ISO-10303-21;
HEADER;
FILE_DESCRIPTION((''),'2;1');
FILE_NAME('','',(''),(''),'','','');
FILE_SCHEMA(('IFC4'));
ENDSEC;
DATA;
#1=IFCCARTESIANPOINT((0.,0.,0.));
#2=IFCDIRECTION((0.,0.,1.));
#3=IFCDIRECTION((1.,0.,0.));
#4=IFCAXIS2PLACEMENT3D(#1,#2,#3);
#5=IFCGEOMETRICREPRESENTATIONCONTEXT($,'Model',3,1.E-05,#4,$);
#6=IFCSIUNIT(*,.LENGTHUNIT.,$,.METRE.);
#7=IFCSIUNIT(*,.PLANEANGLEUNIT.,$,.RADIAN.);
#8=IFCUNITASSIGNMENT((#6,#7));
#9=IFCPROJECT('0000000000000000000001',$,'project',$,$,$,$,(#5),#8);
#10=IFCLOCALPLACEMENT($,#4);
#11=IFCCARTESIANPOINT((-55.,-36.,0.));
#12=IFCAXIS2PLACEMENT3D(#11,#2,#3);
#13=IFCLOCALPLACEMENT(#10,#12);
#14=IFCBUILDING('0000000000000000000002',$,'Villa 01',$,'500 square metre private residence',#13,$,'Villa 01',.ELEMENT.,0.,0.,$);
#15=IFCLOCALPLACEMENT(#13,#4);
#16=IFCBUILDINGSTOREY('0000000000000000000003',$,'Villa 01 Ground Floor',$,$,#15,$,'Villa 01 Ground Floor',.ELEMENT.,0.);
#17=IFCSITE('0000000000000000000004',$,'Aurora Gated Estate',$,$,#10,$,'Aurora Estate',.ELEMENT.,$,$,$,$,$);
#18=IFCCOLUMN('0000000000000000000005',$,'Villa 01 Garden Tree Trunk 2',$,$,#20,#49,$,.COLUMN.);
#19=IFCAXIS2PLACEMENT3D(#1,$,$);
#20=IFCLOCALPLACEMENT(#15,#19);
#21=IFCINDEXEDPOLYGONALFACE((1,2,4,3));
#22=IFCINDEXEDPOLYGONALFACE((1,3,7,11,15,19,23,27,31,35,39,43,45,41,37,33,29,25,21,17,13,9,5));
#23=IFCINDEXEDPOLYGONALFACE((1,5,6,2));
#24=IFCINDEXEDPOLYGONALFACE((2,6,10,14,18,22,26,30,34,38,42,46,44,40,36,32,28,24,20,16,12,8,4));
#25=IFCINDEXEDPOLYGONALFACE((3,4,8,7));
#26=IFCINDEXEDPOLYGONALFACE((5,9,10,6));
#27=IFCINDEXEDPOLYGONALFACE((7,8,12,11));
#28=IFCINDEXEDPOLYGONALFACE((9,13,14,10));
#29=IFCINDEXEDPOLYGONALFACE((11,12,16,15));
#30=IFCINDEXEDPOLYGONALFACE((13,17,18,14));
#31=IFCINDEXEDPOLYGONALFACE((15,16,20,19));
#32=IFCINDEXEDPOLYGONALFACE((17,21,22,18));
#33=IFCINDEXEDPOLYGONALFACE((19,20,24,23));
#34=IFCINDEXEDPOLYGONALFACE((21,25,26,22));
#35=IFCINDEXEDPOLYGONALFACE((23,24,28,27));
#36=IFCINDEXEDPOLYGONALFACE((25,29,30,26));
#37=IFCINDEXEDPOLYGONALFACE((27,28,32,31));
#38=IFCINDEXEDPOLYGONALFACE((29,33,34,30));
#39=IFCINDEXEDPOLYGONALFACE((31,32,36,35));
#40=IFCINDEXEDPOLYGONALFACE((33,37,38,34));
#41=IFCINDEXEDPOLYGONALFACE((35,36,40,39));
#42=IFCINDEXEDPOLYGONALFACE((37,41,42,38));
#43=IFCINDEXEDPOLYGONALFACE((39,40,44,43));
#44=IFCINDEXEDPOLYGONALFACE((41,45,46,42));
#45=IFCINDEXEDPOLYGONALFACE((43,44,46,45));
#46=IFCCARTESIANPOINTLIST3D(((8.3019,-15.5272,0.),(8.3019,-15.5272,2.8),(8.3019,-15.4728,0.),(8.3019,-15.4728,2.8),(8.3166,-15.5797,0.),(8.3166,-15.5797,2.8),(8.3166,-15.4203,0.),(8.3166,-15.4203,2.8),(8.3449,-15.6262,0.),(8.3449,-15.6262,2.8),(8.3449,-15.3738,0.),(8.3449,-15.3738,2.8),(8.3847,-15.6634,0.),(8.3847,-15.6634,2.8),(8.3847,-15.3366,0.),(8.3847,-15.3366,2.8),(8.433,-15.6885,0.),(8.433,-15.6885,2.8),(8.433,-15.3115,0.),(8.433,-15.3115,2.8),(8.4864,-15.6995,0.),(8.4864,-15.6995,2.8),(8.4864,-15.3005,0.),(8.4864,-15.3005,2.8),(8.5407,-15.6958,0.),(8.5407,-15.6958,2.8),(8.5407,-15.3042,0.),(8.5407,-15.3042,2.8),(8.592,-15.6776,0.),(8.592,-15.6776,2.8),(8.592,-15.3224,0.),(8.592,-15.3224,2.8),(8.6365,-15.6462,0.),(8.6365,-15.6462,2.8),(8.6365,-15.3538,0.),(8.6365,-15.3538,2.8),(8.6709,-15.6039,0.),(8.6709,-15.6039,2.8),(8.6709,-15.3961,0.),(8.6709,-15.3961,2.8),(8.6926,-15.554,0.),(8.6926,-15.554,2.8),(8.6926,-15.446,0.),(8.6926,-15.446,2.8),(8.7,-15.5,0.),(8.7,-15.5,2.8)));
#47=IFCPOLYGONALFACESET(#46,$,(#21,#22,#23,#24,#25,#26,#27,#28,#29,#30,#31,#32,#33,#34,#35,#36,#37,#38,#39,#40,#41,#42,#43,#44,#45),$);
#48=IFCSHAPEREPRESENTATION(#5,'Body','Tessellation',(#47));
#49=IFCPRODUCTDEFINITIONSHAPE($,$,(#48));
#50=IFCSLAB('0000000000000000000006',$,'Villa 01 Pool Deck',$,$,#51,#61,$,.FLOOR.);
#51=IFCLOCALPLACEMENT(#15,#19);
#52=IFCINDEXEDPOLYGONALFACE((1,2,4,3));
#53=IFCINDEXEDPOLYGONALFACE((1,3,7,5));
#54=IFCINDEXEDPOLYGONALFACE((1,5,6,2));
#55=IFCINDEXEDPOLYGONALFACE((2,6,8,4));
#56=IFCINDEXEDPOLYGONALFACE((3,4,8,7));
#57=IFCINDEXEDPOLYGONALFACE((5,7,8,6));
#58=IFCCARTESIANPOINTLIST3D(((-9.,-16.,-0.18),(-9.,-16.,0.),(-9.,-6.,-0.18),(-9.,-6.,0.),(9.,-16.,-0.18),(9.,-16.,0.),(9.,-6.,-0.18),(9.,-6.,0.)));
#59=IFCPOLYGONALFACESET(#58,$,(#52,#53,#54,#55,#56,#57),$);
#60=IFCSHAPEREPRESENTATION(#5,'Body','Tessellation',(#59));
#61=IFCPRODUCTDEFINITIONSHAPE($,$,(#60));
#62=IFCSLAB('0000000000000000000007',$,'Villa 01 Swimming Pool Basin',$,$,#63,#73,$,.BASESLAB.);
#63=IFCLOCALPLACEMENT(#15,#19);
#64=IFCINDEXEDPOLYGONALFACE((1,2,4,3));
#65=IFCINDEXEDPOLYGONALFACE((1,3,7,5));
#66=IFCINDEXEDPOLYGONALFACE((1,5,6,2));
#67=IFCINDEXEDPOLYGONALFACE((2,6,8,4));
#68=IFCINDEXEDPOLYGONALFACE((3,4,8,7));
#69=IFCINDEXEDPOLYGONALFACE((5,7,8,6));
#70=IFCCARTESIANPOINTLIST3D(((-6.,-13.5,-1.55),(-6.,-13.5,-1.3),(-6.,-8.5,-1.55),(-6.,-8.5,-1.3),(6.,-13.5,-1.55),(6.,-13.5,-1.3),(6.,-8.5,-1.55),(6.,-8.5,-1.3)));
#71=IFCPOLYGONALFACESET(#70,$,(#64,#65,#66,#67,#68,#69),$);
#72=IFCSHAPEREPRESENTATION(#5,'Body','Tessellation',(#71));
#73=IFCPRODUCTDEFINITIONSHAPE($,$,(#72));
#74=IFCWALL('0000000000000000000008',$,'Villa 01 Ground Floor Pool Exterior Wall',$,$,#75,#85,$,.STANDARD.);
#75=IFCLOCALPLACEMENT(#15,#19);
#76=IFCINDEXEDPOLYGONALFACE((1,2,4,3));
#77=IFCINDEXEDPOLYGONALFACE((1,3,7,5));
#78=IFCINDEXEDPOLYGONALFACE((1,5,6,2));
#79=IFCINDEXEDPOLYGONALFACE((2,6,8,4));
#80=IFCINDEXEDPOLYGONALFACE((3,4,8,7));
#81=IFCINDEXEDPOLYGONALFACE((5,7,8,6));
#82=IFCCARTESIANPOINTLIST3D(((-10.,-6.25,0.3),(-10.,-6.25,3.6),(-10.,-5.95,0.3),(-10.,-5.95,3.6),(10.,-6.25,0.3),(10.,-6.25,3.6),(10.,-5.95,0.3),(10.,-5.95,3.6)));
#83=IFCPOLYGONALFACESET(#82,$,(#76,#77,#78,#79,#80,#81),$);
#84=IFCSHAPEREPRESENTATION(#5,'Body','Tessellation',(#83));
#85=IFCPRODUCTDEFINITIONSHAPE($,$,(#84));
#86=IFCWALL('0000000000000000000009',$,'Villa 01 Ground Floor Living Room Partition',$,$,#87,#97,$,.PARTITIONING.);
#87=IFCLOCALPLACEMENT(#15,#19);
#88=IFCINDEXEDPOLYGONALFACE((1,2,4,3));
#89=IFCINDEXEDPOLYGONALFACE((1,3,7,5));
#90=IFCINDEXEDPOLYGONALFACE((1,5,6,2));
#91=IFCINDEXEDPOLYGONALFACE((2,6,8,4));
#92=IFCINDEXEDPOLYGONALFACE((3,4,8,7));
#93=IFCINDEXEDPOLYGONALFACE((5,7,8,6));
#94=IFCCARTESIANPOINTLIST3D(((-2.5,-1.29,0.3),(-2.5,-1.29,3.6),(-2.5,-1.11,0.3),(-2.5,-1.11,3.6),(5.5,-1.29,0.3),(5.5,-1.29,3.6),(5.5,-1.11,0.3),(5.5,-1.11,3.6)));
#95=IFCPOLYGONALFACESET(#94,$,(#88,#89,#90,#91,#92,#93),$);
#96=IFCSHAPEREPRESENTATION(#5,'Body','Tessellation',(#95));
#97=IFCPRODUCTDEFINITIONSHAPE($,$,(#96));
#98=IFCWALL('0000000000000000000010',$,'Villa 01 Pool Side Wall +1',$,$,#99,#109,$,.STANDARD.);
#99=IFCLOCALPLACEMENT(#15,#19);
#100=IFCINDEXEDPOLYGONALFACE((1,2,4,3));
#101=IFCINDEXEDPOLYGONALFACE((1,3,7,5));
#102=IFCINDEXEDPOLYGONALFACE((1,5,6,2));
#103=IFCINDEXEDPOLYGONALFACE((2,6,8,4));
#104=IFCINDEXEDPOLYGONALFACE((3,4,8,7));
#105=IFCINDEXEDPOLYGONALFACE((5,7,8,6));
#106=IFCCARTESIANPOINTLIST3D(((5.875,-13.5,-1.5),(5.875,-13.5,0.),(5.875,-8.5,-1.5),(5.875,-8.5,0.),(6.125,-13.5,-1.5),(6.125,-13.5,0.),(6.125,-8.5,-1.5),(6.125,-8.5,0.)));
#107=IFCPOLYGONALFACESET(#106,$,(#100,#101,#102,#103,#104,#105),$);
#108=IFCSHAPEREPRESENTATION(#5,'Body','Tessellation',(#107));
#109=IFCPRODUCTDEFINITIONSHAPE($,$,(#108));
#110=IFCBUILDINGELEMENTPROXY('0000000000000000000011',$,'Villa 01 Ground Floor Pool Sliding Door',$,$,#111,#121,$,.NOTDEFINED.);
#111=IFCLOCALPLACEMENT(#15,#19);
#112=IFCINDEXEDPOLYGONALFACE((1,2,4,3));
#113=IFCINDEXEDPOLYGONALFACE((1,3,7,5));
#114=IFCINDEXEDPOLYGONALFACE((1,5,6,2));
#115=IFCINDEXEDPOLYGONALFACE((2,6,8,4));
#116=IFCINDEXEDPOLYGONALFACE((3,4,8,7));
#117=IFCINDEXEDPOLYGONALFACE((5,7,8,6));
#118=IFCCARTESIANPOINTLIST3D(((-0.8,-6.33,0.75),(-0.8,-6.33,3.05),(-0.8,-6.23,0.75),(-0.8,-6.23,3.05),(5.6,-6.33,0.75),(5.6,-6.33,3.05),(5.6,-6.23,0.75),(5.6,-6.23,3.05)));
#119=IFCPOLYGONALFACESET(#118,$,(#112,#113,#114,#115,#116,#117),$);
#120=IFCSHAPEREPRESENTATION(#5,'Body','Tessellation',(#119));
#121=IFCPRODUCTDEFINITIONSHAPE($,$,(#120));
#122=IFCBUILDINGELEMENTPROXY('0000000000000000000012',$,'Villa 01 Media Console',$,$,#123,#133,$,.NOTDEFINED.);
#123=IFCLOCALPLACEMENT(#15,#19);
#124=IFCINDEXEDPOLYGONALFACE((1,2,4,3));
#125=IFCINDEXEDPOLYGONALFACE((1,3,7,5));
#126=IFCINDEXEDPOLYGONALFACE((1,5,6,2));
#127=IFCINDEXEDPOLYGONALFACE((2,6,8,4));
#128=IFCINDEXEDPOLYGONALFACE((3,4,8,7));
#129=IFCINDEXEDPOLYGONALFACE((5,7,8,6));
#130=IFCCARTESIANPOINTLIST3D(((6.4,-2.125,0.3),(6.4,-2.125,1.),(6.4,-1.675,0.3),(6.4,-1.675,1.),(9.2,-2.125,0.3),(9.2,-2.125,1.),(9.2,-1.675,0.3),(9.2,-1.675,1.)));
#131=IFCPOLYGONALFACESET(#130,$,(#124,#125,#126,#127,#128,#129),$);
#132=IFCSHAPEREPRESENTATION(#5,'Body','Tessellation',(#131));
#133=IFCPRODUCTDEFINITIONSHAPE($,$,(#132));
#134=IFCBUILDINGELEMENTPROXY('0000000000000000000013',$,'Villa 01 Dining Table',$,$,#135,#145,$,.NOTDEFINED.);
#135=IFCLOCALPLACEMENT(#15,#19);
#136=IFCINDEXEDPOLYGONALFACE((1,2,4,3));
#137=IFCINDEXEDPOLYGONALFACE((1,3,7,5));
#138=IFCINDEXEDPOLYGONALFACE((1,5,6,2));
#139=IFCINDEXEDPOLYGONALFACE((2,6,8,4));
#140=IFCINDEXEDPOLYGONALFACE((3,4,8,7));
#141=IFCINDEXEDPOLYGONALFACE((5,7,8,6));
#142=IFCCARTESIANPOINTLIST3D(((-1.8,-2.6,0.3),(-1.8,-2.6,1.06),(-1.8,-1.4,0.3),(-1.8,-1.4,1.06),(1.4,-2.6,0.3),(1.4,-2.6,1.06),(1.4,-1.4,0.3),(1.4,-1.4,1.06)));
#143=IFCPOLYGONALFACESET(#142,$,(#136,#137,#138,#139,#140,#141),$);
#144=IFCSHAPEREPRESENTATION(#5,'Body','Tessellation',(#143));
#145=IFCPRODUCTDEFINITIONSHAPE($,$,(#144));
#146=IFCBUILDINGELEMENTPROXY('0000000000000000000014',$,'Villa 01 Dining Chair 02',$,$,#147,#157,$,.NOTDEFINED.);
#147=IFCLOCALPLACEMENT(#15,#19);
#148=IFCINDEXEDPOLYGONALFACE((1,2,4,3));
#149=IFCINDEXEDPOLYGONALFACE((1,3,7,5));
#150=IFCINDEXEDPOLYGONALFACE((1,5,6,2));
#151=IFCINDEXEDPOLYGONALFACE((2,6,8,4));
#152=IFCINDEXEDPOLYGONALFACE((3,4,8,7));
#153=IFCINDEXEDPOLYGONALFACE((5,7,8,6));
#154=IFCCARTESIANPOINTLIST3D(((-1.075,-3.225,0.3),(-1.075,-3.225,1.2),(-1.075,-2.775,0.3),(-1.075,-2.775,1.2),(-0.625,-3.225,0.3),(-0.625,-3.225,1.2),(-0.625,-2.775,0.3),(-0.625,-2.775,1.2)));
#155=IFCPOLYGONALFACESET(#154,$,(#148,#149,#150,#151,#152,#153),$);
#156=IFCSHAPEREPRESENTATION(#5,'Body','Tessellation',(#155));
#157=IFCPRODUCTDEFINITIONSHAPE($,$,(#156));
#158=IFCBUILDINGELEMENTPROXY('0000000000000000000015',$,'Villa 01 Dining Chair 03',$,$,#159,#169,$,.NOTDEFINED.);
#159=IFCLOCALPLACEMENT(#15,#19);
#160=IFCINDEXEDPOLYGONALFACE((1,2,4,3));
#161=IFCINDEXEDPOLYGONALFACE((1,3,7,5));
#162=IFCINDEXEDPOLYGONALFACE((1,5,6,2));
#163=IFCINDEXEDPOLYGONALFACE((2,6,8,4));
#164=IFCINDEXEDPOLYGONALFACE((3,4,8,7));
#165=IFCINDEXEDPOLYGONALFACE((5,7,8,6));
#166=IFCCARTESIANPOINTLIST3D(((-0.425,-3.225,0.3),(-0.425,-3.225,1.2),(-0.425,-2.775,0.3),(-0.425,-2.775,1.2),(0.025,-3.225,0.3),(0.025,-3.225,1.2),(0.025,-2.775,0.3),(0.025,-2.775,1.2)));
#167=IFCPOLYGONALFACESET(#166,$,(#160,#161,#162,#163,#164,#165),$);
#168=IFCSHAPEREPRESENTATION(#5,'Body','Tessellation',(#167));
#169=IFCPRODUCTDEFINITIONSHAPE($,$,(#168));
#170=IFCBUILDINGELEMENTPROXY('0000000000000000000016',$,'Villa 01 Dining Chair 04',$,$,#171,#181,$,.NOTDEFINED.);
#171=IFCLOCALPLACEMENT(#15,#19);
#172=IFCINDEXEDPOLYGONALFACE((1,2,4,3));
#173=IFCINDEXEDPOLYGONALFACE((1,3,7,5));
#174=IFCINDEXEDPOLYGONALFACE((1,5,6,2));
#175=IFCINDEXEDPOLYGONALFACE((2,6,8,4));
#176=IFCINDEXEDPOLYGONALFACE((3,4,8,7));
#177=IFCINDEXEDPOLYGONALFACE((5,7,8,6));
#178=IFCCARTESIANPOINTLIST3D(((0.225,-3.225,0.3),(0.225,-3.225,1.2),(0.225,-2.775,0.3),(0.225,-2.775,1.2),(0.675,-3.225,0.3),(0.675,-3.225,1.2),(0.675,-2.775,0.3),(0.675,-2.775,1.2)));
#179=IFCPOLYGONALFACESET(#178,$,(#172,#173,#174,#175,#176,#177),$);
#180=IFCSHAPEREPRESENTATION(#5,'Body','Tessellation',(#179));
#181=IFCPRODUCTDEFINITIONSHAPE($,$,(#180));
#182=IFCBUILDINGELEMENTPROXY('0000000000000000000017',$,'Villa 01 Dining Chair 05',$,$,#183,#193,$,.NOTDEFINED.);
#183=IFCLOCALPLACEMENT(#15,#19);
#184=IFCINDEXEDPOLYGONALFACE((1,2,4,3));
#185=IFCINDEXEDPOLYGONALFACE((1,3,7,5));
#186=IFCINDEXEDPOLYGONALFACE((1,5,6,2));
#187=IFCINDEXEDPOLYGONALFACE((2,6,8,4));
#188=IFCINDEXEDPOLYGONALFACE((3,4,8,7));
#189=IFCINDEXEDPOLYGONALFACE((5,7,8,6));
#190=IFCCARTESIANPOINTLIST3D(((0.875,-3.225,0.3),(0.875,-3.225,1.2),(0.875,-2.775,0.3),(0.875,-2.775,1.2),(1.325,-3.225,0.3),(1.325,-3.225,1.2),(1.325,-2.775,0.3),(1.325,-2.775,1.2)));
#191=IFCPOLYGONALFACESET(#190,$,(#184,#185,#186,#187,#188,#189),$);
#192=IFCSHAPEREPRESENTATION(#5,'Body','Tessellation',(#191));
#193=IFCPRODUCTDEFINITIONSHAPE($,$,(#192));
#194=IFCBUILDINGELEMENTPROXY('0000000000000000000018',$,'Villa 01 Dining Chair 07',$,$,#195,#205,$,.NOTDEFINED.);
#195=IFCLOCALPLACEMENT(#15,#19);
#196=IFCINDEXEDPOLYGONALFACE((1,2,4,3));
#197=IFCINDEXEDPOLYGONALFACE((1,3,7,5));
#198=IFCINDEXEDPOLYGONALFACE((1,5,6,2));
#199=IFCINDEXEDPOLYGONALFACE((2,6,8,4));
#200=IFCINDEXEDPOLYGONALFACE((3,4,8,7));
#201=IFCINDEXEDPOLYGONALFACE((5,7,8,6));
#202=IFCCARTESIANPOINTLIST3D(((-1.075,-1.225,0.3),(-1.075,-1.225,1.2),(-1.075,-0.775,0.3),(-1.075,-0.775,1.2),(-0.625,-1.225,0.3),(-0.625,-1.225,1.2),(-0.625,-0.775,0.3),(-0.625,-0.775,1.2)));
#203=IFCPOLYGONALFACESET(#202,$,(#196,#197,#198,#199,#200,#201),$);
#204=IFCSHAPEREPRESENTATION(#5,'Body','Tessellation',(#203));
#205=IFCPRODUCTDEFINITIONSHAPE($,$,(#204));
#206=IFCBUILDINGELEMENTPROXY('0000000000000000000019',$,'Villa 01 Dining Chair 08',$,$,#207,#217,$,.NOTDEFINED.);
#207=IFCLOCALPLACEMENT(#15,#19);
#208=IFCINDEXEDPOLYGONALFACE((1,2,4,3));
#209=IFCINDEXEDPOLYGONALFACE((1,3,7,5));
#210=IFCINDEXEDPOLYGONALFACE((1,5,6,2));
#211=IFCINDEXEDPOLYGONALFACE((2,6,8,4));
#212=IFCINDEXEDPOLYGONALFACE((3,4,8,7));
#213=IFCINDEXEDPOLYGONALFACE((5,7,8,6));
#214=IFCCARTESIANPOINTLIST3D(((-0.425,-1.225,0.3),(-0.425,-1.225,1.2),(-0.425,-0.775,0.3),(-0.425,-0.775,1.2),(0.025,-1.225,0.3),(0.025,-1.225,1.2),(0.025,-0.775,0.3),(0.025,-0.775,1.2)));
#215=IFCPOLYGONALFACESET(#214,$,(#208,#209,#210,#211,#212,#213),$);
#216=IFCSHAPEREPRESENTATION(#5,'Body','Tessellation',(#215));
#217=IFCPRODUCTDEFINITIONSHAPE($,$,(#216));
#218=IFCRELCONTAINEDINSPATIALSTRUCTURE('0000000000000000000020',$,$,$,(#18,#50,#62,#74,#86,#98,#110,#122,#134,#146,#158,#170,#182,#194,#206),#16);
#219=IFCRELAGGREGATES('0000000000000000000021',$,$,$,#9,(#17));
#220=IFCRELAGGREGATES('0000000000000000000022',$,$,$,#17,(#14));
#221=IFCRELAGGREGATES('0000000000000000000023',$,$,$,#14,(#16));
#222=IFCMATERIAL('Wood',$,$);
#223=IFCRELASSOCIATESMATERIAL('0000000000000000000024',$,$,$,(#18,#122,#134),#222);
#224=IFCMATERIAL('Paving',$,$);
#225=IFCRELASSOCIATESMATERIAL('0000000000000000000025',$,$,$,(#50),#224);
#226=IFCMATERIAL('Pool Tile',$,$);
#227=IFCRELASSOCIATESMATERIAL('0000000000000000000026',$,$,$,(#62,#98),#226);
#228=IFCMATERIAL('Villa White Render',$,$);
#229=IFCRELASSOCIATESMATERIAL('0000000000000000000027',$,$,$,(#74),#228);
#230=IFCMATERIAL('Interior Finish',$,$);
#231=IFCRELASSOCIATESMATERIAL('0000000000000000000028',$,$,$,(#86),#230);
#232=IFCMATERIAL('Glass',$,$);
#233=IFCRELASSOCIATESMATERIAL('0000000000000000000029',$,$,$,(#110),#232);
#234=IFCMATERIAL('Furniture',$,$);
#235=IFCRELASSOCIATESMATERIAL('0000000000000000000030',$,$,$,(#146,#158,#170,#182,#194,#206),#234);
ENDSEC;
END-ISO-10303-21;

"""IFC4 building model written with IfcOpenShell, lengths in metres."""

from ifc_helpers import new_model, si_unit, frame, origin_with_axes, origin_2d_with_axis, place, context, project, spatial, rectangle, circle, extrude, material, element, save


model = new_model("IFC4")

# Units and contexts
model_context = context("Model", 3, precision=1e-05, world=origin_with_axes())
ifc_project = project(units=[si_unit("LENGTHUNIT", "METRE"), si_unit("PLANEANGLEUNIT", "RADIAN")], contexts=[model_context])

# Site, building, storey
site_placement = place(None, origin_with_axes())
site = spatial("IfcSite", under=ifc_project, at=site_placement, Name="Aurora Gated Estate", LongName="Aurora Estate", CompositionType="ELEMENT")
building_placement = place(site_placement, frame((-55.0, -36.0, 0.0), z_axis=(0.0, 0.0, 1.0), x_axis=(1.0, 0.0, 0.0)))
building = spatial("IfcBuilding", under=site, at=building_placement, Name="Villa 01", ObjectType="500 square metre private residence", LongName="Villa 01", CompositionType="ELEMENT", ElevationOfRefHeight=0.0, ElevationOfTerrain=0.0)
storey_placement = place(building_placement, origin_with_axes())
storey = spatial("IfcBuildingStorey", under=building, at=storey_placement, Name="Villa 01 Ground Floor", LongName="Villa 01 Ground Floor", CompositionType="ELEMENT", Elevation=0.0)

# Column
ifc_material_1 = material(Name="Wood")
column_placement = place(storey_placement, frame((8.5, -15.5, 0.0), z_axis=(0.0, 0.0, 1.0), x_axis=(1.0, 0.0, 0.0)))
element("IfcColumn", 1, at=column_placement, inside=storey, material=ifc_material_1, Name="Villa 01 Garden Tree Trunk 2", PredefinedType="COLUMN", context=model_context, shape_type="SweptSolid", body=[
    extrude(circle(Radius=0.2, at=origin_2d_with_axis()), origin_with_axes(), (0.0, 0.0, 1.0), 2.8),
])

# Slabs
ifc_material_2 = material(Name="Paving")
slab_1_placement = place(storey_placement, frame((0.0, -11.0, -0.18), z_axis=(0.0, 0.0, 1.0), x_axis=(1.0, 0.0, 0.0)))
element("IfcSlab", 2, at=slab_1_placement, inside=storey, material=ifc_material_2, Name="Villa 01 Pool Deck", PredefinedType="FLOOR", context=model_context, shape_type="SweptSolid", body=[
    extrude(rectangle(XDim=18.0, YDim=10.0, at=origin_2d_with_axis()), origin_with_axes(), (0.0, 0.0, 1.0), 0.18),
])
ifc_material_3 = material(Name="Pool Tile")
slab_2_placement = place(storey_placement, frame((0.0, -11.0, -1.55), z_axis=(0.0, 0.0, 1.0), x_axis=(1.0, 0.0, 0.0)))
element("IfcSlab", 3, at=slab_2_placement, inside=storey, material=ifc_material_3, Name="Villa 01 Swimming Pool Basin", PredefinedType="BASESLAB", context=model_context, shape_type="SweptSolid", body=[
    extrude(rectangle(XDim=12.0, YDim=5.0, at=origin_2d_with_axis()), origin_with_axes(), (0.0, 0.0, 1.0), 0.25),
])

# Walls
ifc_material_4 = material(Name="Villa White Render")
wall_1_placement = place(storey_placement, frame((0.0, -6.1, 0.3), z_axis=(0.0, 0.0, 1.0), x_axis=(1.0, 0.0, 0.0)))
element("IfcWall", 4, at=wall_1_placement, inside=storey, material=ifc_material_4, Name="Villa 01 Ground Floor Pool Exterior Wall", PredefinedType="STANDARD", context=model_context, shape_type="SweptSolid", body=[
    extrude(rectangle(XDim=20.0, YDim=0.3, at=origin_2d_with_axis()), origin_with_axes(), (0.0, 0.0, 1.0), 3.3),
])
ifc_material_5 = material(Name="Interior Finish")
wall_2_placement = place(storey_placement, frame((1.5, -1.2, 0.3), z_axis=(0.0, 0.0, 1.0), x_axis=(1.0, 0.0, 0.0)))
element("IfcWall", 5, at=wall_2_placement, inside=storey, material=ifc_material_5, Name="Villa 01 Ground Floor Living Room Partition", PredefinedType="PARTITIONING", context=model_context, shape_type="SweptSolid", body=[
    extrude(rectangle(XDim=8.0, YDim=0.18, at=origin_2d_with_axis()), origin_with_axes(), (0.0, 0.0, 1.0), 3.3),
])
wall_3_placement = place(storey_placement, frame((6.0, -11.0, -1.5), z_axis=(0.0, 0.0, 1.0), x_axis=(1.0, 0.0, 0.0)))
element("IfcWall", 6, at=wall_3_placement, inside=storey, material=ifc_material_3, Name="Villa 01 Pool Side Wall +1", PredefinedType="STANDARD", context=model_context, shape_type="SweptSolid", body=[
    extrude(rectangle(XDim=0.25, YDim=5.0, at=origin_2d_with_axis()), origin_with_axes(), (0.0, 0.0, 1.0), 1.5),
])

# Building element proxies
ifc_material_6 = material(Name="Glass")
proxy_1_placement = place(storey_placement, frame((2.4, -6.28, 0.75), z_axis=(0.0, 0.0, 1.0), x_axis=(1.0, 0.0, 0.0)))
element("IfcBuildingElementProxy", 7, at=proxy_1_placement, inside=storey, material=ifc_material_6, Name="Villa 01 Ground Floor Pool Sliding Door", PredefinedType="NOTDEFINED", context=model_context, shape_type="SweptSolid", body=[
    extrude(rectangle(XDim=6.4, YDim=0.1, at=origin_2d_with_axis()), origin_with_axes(), (0.0, 0.0, 1.0), 2.3),
])
proxy_2_placement = place(storey_placement, frame((7.8, -1.9, 0.3), z_axis=(0.0, 0.0, 1.0), x_axis=(1.0, 0.0, 0.0)))
element("IfcBuildingElementProxy", 8, at=proxy_2_placement, inside=storey, material=ifc_material_1, Name="Villa 01 Media Console", PredefinedType="NOTDEFINED", context=model_context, shape_type="SweptSolid", body=[
    extrude(rectangle(XDim=2.8, YDim=0.45, at=origin_2d_with_axis()), origin_with_axes(), (0.0, 0.0, 1.0), 0.7),
])
proxy_3_placement = place(storey_placement, frame((-0.2, -2.0, 0.3), z_axis=(0.0, 0.0, 1.0), x_axis=(1.0, 0.0, 0.0)))
element("IfcBuildingElementProxy", 9, at=proxy_3_placement, inside=storey, material=ifc_material_1, Name="Villa 01 Dining Table", PredefinedType="NOTDEFINED", context=model_context, shape_type="SweptSolid", body=[
    extrude(rectangle(XDim=3.2, YDim=1.2, at=origin_2d_with_axis()), origin_with_axes(), (0.0, 0.0, 1.0), 0.76),
])
ifc_material_7 = material(Name="Furniture")
for number, where, z_axis, x_axis, name in (
    (10, (-0.85, -3.0, 0.3), (0.0, 0.0, 1.0), (1.0, 0.0, 0.0), "Villa 01 Dining Chair 02"),
    (11, (-0.2, -3.0, 0.3), (0.0, 0.0, 1.0), (1.0, 0.0, 0.0), "Villa 01 Dining Chair 03"),
    (12, (0.45, -3.0, 0.3), (0.0, 0.0, 1.0), (1.0, 0.0, 0.0), "Villa 01 Dining Chair 04"),
    (13, (1.1, -3.0, 0.3), (0.0, 0.0, 1.0), (1.0, 0.0, 0.0), "Villa 01 Dining Chair 05"),
    (14, (-0.85, -1.0, 0.3), (0.0, 0.0, 1.0), (1.0, 0.0, 0.0), "Villa 01 Dining Chair 07"),
    (15, (-0.2, -1.0, 0.3), (0.0, 0.0, 1.0), (1.0, 0.0, 0.0), "Villa 01 Dining Chair 08"),
):
    element("IfcBuildingElementProxy", number, at=place(storey_placement, frame(where, z_axis=z_axis, x_axis=x_axis)), inside=storey, material=ifc_material_7, Name=name, PredefinedType="NOTDEFINED", context=model_context, shape_type="SweptSolid", body=[
        extrude(rectangle(XDim=0.45, YDim=0.45, at=origin_2d_with_axis()), origin_with_axes(), (0.0, 0.0, 1.0), 0.9),
    ])

save(model, "model.ifc")
